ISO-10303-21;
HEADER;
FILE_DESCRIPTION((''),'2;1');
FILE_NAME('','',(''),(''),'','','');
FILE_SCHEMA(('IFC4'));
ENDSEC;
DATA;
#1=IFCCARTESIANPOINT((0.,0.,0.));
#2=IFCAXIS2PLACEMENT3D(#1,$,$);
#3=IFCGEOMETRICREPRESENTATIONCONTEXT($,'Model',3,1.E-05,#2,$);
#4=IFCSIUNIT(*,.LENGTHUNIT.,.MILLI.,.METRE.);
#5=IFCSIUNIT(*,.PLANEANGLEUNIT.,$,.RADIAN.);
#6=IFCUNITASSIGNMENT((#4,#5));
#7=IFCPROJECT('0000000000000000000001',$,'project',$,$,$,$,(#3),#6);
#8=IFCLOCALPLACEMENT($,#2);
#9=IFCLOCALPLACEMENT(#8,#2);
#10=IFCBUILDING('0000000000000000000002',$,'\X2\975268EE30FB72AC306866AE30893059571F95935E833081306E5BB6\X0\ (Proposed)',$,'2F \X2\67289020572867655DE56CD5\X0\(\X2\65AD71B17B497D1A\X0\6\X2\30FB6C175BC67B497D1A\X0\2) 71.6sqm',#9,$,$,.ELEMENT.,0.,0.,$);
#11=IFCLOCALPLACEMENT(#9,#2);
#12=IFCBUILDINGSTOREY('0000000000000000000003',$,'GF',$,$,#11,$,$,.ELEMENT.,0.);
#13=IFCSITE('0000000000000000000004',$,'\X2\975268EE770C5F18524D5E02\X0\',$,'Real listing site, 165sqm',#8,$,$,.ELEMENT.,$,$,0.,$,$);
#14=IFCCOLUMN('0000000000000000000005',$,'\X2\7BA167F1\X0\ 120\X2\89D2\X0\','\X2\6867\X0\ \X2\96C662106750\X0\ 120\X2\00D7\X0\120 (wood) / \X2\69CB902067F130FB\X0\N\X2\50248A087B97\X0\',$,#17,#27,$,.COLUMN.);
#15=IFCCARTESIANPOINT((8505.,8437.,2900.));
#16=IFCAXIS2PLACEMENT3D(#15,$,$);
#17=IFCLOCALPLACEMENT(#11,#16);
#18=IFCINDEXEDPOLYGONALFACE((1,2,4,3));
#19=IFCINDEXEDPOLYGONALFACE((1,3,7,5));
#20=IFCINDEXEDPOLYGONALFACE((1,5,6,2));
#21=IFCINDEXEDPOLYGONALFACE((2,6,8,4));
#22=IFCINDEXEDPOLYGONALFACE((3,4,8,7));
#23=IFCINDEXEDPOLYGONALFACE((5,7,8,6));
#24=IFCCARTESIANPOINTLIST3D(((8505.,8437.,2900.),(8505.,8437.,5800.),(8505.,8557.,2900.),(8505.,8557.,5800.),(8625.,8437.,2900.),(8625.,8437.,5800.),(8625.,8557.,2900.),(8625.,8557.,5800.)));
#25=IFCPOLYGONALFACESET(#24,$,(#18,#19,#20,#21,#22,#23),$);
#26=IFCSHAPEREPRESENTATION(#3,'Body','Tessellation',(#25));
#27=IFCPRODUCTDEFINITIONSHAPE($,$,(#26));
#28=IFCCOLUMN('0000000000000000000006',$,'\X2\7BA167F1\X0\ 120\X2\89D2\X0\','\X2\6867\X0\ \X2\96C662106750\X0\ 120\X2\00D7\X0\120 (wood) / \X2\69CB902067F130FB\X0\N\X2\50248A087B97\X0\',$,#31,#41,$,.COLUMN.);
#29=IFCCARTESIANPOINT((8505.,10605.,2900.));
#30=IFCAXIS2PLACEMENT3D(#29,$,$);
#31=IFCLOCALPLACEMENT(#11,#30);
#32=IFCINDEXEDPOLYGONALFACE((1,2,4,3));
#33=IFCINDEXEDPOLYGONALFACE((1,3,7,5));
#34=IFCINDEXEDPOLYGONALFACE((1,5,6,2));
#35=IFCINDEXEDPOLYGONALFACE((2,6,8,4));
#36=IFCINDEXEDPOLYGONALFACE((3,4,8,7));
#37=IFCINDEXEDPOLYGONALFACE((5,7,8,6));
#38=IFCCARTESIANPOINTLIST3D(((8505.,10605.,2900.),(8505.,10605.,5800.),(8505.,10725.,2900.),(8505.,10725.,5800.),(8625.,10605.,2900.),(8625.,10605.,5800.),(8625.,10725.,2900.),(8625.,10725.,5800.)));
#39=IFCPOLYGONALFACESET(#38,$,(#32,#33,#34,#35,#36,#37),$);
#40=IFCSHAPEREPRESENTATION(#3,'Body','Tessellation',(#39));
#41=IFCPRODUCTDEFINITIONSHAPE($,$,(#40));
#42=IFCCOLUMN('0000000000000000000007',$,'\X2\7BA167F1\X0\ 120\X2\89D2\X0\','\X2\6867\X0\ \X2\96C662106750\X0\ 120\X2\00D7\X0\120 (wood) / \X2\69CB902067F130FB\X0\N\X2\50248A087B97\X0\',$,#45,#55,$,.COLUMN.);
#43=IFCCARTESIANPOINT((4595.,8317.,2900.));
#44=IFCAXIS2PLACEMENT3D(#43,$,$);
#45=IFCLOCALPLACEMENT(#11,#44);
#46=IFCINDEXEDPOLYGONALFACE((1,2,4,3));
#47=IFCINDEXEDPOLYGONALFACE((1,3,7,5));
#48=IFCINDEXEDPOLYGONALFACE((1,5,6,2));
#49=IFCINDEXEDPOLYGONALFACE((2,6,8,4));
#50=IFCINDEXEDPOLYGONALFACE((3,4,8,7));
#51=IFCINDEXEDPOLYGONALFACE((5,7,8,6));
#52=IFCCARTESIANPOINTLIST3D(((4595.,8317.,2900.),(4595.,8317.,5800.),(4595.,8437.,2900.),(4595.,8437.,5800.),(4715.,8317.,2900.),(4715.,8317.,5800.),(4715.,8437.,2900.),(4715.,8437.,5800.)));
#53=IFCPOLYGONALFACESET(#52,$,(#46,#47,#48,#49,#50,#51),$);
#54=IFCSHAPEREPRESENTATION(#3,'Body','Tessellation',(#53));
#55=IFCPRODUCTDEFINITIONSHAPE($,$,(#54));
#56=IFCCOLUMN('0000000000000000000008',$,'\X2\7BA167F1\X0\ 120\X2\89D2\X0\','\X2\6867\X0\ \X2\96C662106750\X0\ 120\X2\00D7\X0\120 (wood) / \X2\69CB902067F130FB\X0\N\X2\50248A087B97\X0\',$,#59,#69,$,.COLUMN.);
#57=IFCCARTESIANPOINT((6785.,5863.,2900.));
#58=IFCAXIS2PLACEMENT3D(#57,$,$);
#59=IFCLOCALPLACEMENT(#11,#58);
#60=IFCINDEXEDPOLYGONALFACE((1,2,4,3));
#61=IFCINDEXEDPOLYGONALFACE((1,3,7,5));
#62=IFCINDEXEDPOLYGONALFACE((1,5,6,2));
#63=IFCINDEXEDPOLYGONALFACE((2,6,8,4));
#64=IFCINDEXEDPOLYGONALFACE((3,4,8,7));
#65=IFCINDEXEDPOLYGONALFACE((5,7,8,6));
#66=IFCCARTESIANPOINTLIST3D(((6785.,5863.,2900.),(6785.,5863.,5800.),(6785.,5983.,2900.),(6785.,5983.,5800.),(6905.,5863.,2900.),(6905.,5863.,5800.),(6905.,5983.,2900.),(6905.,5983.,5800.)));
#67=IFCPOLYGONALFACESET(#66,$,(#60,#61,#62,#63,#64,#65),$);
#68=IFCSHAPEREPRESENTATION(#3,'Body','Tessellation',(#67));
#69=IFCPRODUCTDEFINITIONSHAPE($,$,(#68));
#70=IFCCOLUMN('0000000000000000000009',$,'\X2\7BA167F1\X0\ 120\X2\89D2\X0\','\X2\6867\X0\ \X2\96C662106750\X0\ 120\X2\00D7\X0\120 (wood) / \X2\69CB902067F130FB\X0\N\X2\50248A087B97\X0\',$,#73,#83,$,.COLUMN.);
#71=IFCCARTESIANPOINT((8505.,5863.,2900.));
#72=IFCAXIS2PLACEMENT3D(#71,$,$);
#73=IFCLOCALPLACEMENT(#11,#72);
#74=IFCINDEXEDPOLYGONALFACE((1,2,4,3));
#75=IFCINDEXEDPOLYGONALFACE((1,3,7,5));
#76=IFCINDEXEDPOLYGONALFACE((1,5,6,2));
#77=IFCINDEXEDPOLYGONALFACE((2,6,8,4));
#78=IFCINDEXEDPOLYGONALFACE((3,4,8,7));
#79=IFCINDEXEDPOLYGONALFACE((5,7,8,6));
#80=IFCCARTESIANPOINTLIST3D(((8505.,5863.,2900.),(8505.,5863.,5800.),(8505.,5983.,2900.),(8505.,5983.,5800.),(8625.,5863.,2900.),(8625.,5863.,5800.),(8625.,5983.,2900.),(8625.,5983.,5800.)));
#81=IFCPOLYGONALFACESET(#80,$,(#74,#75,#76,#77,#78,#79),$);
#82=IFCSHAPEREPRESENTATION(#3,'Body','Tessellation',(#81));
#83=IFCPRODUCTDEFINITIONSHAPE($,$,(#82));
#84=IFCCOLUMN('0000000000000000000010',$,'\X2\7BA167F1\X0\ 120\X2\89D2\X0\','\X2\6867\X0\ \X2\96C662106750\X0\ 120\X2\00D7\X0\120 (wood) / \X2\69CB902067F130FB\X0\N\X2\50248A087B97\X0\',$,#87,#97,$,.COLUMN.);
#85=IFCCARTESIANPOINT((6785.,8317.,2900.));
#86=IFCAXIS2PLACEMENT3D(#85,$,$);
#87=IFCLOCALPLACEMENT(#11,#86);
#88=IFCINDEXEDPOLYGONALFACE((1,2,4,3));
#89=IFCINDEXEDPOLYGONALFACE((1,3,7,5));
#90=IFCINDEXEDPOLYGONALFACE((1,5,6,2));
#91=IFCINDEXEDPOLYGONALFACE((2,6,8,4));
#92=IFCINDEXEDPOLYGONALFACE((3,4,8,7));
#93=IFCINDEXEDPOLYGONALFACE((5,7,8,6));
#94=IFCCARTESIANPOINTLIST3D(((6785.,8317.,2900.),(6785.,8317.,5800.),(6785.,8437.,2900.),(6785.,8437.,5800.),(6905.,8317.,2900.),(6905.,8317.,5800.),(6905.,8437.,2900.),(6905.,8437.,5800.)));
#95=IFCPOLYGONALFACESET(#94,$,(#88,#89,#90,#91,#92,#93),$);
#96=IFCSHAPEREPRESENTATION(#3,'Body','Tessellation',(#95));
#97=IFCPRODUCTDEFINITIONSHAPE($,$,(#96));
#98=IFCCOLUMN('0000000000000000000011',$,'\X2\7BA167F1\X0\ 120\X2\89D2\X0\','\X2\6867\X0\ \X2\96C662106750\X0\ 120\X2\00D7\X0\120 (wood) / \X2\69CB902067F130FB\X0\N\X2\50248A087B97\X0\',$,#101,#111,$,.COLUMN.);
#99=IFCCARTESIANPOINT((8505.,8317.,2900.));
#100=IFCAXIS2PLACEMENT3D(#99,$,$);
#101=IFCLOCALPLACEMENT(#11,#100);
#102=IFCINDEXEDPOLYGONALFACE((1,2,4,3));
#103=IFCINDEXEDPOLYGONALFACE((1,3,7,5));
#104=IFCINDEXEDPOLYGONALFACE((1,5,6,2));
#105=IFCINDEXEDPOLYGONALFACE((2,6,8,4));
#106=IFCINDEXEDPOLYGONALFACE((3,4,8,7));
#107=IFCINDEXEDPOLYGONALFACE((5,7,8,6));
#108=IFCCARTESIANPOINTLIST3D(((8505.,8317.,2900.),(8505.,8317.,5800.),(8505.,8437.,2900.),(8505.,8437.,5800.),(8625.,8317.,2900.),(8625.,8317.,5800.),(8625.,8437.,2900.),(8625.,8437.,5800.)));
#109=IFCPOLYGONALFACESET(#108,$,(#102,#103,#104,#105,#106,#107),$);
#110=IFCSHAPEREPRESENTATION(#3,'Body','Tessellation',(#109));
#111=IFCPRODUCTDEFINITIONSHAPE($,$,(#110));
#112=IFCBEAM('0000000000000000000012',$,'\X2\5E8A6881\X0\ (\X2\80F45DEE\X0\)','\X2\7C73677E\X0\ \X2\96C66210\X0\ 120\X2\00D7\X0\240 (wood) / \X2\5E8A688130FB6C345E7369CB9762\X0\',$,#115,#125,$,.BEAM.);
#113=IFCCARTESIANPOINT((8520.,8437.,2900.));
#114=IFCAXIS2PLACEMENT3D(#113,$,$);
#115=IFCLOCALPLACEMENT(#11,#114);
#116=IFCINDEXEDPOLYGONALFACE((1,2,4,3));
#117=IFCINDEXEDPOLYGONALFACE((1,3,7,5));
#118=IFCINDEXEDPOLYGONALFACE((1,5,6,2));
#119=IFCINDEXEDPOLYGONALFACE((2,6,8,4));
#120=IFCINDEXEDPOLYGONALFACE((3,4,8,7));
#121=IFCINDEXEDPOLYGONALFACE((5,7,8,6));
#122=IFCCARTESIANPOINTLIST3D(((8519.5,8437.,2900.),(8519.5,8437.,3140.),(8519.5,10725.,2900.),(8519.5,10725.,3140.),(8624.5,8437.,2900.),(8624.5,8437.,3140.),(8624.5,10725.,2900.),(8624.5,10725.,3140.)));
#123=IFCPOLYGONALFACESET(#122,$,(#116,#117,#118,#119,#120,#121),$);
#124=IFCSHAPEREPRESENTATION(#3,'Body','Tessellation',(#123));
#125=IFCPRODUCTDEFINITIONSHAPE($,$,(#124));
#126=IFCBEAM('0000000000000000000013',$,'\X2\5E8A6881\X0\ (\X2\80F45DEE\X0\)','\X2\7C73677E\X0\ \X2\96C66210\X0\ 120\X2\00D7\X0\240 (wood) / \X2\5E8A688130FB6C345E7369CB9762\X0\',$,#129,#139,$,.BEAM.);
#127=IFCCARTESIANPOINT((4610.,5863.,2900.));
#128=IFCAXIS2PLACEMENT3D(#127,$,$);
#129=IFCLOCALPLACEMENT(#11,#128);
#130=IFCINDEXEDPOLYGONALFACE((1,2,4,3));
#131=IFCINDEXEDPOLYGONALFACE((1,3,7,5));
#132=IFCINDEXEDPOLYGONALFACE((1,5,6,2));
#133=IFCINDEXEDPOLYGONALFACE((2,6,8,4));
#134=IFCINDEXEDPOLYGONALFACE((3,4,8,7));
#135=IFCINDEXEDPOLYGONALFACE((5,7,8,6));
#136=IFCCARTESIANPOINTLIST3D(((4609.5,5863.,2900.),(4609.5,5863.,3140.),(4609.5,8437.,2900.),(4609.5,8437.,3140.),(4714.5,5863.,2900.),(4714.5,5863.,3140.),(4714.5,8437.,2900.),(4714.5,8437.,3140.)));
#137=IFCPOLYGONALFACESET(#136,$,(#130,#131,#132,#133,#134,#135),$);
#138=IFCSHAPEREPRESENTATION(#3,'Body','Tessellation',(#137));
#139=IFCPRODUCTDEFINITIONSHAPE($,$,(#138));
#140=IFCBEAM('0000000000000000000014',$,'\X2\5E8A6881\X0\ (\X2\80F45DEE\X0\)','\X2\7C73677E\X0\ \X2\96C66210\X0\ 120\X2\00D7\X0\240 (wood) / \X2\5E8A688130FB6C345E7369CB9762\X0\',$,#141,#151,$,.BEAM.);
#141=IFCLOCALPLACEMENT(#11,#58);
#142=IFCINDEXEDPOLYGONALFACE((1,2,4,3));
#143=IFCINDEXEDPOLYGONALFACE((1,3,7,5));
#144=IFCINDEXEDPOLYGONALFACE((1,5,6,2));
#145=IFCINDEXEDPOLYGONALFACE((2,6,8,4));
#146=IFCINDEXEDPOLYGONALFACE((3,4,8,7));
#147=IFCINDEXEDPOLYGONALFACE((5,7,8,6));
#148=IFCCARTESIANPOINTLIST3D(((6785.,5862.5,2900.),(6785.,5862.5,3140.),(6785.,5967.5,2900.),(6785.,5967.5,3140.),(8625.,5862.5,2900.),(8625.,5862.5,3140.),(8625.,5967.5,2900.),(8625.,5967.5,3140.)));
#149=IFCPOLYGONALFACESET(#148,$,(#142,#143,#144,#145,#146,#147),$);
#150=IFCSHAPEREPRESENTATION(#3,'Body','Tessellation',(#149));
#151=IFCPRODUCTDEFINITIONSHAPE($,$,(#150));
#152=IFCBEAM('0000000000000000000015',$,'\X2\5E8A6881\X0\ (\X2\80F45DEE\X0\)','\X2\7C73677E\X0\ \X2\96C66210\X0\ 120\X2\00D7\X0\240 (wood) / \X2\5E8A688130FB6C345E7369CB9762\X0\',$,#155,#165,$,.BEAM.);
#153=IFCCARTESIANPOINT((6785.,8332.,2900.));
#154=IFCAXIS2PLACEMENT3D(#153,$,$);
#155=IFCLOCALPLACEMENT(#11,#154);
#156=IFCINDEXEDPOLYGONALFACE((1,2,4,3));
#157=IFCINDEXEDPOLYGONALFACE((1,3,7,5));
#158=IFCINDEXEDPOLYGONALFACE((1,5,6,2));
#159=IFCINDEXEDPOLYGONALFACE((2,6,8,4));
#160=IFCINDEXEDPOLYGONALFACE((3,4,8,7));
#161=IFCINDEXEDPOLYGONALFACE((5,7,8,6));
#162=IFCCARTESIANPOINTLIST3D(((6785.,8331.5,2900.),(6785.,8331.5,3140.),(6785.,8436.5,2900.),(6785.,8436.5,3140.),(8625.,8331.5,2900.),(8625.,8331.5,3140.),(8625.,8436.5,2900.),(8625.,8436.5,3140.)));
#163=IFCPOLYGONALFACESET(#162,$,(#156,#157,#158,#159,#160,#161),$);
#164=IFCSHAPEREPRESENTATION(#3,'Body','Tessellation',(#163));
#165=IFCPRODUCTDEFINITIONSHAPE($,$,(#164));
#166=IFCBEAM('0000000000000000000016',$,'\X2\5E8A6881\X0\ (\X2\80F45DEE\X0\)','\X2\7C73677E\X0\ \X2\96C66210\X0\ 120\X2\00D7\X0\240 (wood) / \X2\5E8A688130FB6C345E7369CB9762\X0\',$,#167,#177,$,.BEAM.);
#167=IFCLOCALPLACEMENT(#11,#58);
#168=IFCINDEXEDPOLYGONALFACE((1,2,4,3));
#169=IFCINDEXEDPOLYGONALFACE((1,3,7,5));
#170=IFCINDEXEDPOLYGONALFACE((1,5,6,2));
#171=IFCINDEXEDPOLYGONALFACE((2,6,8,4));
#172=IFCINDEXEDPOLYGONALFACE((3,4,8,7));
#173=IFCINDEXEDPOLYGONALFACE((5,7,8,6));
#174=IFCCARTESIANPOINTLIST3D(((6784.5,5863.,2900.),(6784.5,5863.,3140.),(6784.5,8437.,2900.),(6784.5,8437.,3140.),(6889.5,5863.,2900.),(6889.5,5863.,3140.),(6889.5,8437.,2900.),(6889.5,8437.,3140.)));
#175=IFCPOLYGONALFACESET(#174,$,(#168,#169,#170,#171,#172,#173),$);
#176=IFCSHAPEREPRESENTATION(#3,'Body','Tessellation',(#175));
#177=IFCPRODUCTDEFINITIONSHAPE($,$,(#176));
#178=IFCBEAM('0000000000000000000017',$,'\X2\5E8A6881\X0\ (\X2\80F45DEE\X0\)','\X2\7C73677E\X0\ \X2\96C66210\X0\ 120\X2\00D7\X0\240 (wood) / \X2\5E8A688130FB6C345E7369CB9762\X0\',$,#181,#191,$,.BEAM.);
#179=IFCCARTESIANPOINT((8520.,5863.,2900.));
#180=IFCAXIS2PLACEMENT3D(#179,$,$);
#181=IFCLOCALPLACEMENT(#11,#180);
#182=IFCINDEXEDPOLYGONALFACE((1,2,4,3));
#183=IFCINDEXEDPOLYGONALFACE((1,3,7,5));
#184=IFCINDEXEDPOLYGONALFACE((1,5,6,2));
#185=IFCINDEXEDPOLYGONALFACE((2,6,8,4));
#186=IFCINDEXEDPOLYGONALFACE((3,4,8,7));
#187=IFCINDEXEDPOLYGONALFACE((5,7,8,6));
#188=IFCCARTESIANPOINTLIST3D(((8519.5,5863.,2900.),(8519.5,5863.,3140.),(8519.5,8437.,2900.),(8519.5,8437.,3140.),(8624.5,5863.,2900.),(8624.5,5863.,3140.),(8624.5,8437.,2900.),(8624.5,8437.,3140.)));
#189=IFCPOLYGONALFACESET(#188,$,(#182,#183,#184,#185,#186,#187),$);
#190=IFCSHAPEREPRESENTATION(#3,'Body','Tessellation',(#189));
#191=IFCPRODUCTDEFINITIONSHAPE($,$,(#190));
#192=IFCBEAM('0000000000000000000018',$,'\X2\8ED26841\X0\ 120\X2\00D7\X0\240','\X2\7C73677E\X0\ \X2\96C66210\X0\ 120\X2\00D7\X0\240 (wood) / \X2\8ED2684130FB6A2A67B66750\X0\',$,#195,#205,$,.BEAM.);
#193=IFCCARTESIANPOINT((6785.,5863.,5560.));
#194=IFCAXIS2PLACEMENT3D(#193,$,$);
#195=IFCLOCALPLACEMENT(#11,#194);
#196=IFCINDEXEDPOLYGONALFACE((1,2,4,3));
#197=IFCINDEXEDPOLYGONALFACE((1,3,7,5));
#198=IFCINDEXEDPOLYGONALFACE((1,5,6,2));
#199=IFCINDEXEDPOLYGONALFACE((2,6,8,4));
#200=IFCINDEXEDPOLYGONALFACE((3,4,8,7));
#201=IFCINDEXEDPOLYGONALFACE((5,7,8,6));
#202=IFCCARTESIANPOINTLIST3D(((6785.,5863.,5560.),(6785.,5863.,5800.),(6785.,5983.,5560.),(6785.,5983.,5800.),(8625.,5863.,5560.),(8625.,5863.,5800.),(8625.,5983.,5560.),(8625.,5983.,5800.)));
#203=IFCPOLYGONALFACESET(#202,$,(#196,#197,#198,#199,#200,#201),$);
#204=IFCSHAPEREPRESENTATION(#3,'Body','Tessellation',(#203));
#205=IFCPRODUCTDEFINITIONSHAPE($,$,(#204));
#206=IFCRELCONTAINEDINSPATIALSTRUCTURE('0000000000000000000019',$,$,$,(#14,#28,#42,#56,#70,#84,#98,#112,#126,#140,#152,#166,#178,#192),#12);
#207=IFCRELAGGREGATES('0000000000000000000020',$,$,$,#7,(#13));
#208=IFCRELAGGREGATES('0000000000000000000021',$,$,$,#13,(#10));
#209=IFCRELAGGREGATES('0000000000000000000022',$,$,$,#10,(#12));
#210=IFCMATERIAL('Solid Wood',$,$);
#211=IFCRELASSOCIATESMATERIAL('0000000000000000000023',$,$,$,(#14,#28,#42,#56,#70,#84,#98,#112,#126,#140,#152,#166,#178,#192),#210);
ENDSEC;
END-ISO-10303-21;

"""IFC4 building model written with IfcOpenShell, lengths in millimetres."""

from ifc_helpers import new_model, si_unit, frame, frame_2d, origin, place, context, project, spatial, rectangle, extrude, material, element, save


model = new_model("IFC4")

# Units and contexts
model_context = context("Model", 3, precision=1e-05, world=origin())
ifc_project = project(units=[si_unit("LENGTHUNIT", "METRE", prefix="MILLI"), si_unit("PLANEANGLEUNIT", "RADIAN")], contexts=[model_context])

# Site, building, storey
site_placement = place(None, origin())
site = spatial("IfcSite", under=ifc_project, at=site_placement, Name="青森県弘前市", ObjectType="Real listing site, 165sqm", CompositionType="ELEMENT", RefElevation=0.0)
building_placement = place(site_placement, origin())
building = spatial("IfcBuilding", under=site, at=building_placement, Name="青森・犬と暮らす土間広めの家 (Proposed)", ObjectType="2F 木造在来工法(断熱等級6・気密等級2) 71.6sqm", CompositionType="ELEMENT", ElevationOfRefHeight=0.0, ElevationOfTerrain=0.0)
storey_placement = place(building_placement, origin())
storey = spatial("IfcBuildingStorey", under=building, at=storey_placement, Name="GF", CompositionType="ELEMENT", Elevation=0.0)

# Columns
ifc_material_1 = material(Name="Solid Wood")
column_1_placement = place(storey_placement, frame((8505.0, 8437.0, 2900.0)))
element("IfcColumn", 1, at=column_1_placement, inside=storey, material=ifc_material_1, Name="管柱 120角", Description="桧 集成材 120×120 (wood) / 構造柱・N値計算", PredefinedType="COLUMN", context=model_context, shape_type="SweptSolid", body=[
    extrude(rectangle(XDim=120.0, YDim=120.0, at=frame_2d((60.0, 60.0))), frame((8505.0, 8437.0, 2900.0)), (0.0, 0.0, 1.0), 2900.0),
])
column_2_placement = place(storey_placement, frame((8505.0, 10605.0, 2900.0)))
element("IfcColumn", 2, at=column_2_placement, inside=storey, material=ifc_material_1, Name="管柱 120角", Description="桧 集成材 120×120 (wood) / 構造柱・N値計算", PredefinedType="COLUMN", context=model_context, shape_type="SweptSolid", body=[
    extrude(rectangle(XDim=120.0, YDim=120.0, at=frame_2d((60.0, 60.0))), frame((8505.0, 10605.0, 2900.0)), (0.0, 0.0, 1.0), 2900.0),
])
column_3_placement = place(storey_placement, frame((4595.0, 8317.0, 2900.0)))
element("IfcColumn", 3, at=column_3_placement, inside=storey, material=ifc_material_1, Name="管柱 120角", Description="桧 集成材 120×120 (wood) / 構造柱・N値計算", PredefinedType="COLUMN", context=model_context, shape_type="SweptSolid", body=[
    extrude(rectangle(XDim=120.0, YDim=120.0, at=frame_2d((60.0, 60.0))), frame((4595.0, 8317.0, 2900.0)), (0.0, 0.0, 1.0), 2900.0),
])
column_4_placement = place(storey_placement, frame((6785.0, 5863.0, 2900.0)))
element("IfcColumn", 4, at=column_4_placement, inside=storey, material=ifc_material_1, Name="管柱 120角", Description="桧 集成材 120×120 (wood) / 構造柱・N値計算", PredefinedType="COLUMN", context=model_context, shape_type="SweptSolid", body=[
    extrude(rectangle(XDim=120.0, YDim=120.0, at=frame_2d((60.0, 60.0))), frame((6785.0, 5863.0, 2900.0)), (0.0, 0.0, 1.0), 2900.0),
])
column_5_placement = place(storey_placement, frame((8505.0, 5863.0, 2900.0)))
element("IfcColumn", 5, at=column_5_placement, inside=storey, material=ifc_material_1, Name="管柱 120角", Description="桧 集成材 120×120 (wood) / 構造柱・N値計算", PredefinedType="COLUMN", context=model_context, shape_type="SweptSolid", body=[
    extrude(rectangle(XDim=120.0, YDim=120.0, at=frame_2d((60.0, 60.0))), frame((8505.0, 5863.0, 2900.0)), (0.0, 0.0, 1.0), 2900.0),
])
column_6_placement = place(storey_placement, frame((6785.0, 8317.0, 2900.0)))
element("IfcColumn", 6, at=column_6_placement, inside=storey, material=ifc_material_1, Name="管柱 120角", Description="桧 集成材 120×120 (wood) / 構造柱・N値計算", PredefinedType="COLUMN", context=model_context, shape_type="SweptSolid", body=[
    extrude(rectangle(XDim=120.0, YDim=120.0, at=frame_2d((60.0, 60.0))), frame((6785.0, 8317.0, 2900.0)), (0.0, 0.0, 1.0), 2900.0),
])
column_7_placement = place(storey_placement, frame((8505.0, 8317.0, 2900.0)))
element("IfcColumn", 7, at=column_7_placement, inside=storey, material=ifc_material_1, Name="管柱 120角", Description="桧 集成材 120×120 (wood) / 構造柱・N値計算", PredefinedType="COLUMN", context=model_context, shape_type="SweptSolid", body=[
    extrude(rectangle(XDim=120.0, YDim=120.0, at=frame_2d((60.0, 60.0))), frame((8505.0, 8317.0, 2900.0)), (0.0, 0.0, 1.0), 2900.0),
])

# Beams
beam_1_placement = place(storey_placement, frame((8520.0, 8437.0, 2900.0)))
element("IfcBeam", 8, at=beam_1_placement, inside=storey, material=ifc_material_1, Name="床梁 (胴差)", Description="米松 集成 120×240 (wood) / 床梁・水平構面", PredefinedType="BEAM", context=model_context, shape_type="SweptSolid", body=[
    extrude(rectangle(XDim=105.0, YDim=2288.0, at=frame_2d((52.0, 1144.0))), frame((8520.0, 8437.0, 2900.0)), (0.0, 0.0, 1.0), 240.0),
])
beam_2_placement = place(storey_placement, frame((4610.0, 5863.0, 2900.0)))
element("IfcBeam", 9, at=beam_2_placement, inside=storey, material=ifc_material_1, Name="床梁 (胴差)", Description="米松 集成 120×240 (wood) / 床梁・水平構面", PredefinedType="BEAM", context=model_context, shape_type="SweptSolid", body=[
    extrude(rectangle(XDim=105.0, YDim=2574.0, at=frame_2d((52.0, 1287.0))), frame((4610.0, 5863.0, 2900.0)), (0.0, 0.0, 1.0), 240.0),
])
beam_3_placement = place(storey_placement, frame((6785.0, 5863.0, 2900.0)))
element("IfcBeam", 10, at=beam_3_placement, inside=storey, material=ifc_material_1, Name="床梁 (胴差)", Description="米松 集成 120×240 (wood) / 床梁・水平構面", PredefinedType="BEAM", context=model_context, shape_type="SweptSolid", body=[
    extrude(rectangle(XDim=1840.0, YDim=105.0, at=frame_2d((920.0, 52.0))), frame((6785.0, 5863.0, 2900.0)), (0.0, 0.0, 1.0), 240.0),
])
beam_4_placement = place(storey_placement, frame((6785.0, 8332.0, 2900.0)))
element("IfcBeam", 11, at=beam_4_placement, inside=storey, material=ifc_material_1, Name="床梁 (胴差)", Description="米松 集成 120×240 (wood) / 床梁・水平構面", PredefinedType="BEAM", context=model_context, shape_type="SweptSolid", body=[
    extrude(rectangle(XDim=1840.0, YDim=105.0, at=frame_2d((920.0, 52.0))), frame((6785.0, 8332.0, 2900.0)), (0.0, 0.0, 1.0), 240.0),
])
beam_5_placement = place(storey_placement, frame((6785.0, 5863.0, 2900.0)))
element("IfcBeam", 12, at=beam_5_placement, inside=storey, material=ifc_material_1, Name="床梁 (胴差)", Description="米松 集成 120×240 (wood) / 床梁・水平構面", PredefinedType="BEAM", context=model_context, shape_type="SweptSolid", body=[
    extrude(rectangle(XDim=105.0, YDim=2574.0, at=frame_2d((52.0, 1287.0))), frame((6785.0, 5863.0, 2900.0)), (0.0, 0.0, 1.0), 240.0),
])
beam_6_placement = place(storey_placement, frame((8520.0, 5863.0, 2900.0)))
element("IfcBeam", 13, at=beam_6_placement, inside=storey, material=ifc_material_1, Name="床梁 (胴差)", Description="米松 集成 120×240 (wood) / 床梁・水平構面", PredefinedType="BEAM", context=model_context, shape_type="SweptSolid", body=[
    extrude(rectangle(XDim=105.0, YDim=2574.0, at=frame_2d((52.0, 1287.0))), frame((8520.0, 5863.0, 2900.0)), (0.0, 0.0, 1.0), 240.0),
])
beam_7_placement = place(storey_placement, frame((6785.0, 5863.0, 5560.0)))
element("IfcBeam", 14, at=beam_7_placement, inside=storey, material=ifc_material_1, Name="軒桁 120×240", Description="米松 集成 120×240 (wood) / 軒桁・横架材", PredefinedType="BEAM", context=model_context, shape_type="SweptSolid", body=[
    extrude(rectangle(XDim=1840.0, YDim=120.0, at=frame_2d((920.0, 60.0))), frame((6785.0, 5863.0, 5560.0)), (0.0, 0.0, 1.0), 240.0),
])

save(model, "model.ifc")
